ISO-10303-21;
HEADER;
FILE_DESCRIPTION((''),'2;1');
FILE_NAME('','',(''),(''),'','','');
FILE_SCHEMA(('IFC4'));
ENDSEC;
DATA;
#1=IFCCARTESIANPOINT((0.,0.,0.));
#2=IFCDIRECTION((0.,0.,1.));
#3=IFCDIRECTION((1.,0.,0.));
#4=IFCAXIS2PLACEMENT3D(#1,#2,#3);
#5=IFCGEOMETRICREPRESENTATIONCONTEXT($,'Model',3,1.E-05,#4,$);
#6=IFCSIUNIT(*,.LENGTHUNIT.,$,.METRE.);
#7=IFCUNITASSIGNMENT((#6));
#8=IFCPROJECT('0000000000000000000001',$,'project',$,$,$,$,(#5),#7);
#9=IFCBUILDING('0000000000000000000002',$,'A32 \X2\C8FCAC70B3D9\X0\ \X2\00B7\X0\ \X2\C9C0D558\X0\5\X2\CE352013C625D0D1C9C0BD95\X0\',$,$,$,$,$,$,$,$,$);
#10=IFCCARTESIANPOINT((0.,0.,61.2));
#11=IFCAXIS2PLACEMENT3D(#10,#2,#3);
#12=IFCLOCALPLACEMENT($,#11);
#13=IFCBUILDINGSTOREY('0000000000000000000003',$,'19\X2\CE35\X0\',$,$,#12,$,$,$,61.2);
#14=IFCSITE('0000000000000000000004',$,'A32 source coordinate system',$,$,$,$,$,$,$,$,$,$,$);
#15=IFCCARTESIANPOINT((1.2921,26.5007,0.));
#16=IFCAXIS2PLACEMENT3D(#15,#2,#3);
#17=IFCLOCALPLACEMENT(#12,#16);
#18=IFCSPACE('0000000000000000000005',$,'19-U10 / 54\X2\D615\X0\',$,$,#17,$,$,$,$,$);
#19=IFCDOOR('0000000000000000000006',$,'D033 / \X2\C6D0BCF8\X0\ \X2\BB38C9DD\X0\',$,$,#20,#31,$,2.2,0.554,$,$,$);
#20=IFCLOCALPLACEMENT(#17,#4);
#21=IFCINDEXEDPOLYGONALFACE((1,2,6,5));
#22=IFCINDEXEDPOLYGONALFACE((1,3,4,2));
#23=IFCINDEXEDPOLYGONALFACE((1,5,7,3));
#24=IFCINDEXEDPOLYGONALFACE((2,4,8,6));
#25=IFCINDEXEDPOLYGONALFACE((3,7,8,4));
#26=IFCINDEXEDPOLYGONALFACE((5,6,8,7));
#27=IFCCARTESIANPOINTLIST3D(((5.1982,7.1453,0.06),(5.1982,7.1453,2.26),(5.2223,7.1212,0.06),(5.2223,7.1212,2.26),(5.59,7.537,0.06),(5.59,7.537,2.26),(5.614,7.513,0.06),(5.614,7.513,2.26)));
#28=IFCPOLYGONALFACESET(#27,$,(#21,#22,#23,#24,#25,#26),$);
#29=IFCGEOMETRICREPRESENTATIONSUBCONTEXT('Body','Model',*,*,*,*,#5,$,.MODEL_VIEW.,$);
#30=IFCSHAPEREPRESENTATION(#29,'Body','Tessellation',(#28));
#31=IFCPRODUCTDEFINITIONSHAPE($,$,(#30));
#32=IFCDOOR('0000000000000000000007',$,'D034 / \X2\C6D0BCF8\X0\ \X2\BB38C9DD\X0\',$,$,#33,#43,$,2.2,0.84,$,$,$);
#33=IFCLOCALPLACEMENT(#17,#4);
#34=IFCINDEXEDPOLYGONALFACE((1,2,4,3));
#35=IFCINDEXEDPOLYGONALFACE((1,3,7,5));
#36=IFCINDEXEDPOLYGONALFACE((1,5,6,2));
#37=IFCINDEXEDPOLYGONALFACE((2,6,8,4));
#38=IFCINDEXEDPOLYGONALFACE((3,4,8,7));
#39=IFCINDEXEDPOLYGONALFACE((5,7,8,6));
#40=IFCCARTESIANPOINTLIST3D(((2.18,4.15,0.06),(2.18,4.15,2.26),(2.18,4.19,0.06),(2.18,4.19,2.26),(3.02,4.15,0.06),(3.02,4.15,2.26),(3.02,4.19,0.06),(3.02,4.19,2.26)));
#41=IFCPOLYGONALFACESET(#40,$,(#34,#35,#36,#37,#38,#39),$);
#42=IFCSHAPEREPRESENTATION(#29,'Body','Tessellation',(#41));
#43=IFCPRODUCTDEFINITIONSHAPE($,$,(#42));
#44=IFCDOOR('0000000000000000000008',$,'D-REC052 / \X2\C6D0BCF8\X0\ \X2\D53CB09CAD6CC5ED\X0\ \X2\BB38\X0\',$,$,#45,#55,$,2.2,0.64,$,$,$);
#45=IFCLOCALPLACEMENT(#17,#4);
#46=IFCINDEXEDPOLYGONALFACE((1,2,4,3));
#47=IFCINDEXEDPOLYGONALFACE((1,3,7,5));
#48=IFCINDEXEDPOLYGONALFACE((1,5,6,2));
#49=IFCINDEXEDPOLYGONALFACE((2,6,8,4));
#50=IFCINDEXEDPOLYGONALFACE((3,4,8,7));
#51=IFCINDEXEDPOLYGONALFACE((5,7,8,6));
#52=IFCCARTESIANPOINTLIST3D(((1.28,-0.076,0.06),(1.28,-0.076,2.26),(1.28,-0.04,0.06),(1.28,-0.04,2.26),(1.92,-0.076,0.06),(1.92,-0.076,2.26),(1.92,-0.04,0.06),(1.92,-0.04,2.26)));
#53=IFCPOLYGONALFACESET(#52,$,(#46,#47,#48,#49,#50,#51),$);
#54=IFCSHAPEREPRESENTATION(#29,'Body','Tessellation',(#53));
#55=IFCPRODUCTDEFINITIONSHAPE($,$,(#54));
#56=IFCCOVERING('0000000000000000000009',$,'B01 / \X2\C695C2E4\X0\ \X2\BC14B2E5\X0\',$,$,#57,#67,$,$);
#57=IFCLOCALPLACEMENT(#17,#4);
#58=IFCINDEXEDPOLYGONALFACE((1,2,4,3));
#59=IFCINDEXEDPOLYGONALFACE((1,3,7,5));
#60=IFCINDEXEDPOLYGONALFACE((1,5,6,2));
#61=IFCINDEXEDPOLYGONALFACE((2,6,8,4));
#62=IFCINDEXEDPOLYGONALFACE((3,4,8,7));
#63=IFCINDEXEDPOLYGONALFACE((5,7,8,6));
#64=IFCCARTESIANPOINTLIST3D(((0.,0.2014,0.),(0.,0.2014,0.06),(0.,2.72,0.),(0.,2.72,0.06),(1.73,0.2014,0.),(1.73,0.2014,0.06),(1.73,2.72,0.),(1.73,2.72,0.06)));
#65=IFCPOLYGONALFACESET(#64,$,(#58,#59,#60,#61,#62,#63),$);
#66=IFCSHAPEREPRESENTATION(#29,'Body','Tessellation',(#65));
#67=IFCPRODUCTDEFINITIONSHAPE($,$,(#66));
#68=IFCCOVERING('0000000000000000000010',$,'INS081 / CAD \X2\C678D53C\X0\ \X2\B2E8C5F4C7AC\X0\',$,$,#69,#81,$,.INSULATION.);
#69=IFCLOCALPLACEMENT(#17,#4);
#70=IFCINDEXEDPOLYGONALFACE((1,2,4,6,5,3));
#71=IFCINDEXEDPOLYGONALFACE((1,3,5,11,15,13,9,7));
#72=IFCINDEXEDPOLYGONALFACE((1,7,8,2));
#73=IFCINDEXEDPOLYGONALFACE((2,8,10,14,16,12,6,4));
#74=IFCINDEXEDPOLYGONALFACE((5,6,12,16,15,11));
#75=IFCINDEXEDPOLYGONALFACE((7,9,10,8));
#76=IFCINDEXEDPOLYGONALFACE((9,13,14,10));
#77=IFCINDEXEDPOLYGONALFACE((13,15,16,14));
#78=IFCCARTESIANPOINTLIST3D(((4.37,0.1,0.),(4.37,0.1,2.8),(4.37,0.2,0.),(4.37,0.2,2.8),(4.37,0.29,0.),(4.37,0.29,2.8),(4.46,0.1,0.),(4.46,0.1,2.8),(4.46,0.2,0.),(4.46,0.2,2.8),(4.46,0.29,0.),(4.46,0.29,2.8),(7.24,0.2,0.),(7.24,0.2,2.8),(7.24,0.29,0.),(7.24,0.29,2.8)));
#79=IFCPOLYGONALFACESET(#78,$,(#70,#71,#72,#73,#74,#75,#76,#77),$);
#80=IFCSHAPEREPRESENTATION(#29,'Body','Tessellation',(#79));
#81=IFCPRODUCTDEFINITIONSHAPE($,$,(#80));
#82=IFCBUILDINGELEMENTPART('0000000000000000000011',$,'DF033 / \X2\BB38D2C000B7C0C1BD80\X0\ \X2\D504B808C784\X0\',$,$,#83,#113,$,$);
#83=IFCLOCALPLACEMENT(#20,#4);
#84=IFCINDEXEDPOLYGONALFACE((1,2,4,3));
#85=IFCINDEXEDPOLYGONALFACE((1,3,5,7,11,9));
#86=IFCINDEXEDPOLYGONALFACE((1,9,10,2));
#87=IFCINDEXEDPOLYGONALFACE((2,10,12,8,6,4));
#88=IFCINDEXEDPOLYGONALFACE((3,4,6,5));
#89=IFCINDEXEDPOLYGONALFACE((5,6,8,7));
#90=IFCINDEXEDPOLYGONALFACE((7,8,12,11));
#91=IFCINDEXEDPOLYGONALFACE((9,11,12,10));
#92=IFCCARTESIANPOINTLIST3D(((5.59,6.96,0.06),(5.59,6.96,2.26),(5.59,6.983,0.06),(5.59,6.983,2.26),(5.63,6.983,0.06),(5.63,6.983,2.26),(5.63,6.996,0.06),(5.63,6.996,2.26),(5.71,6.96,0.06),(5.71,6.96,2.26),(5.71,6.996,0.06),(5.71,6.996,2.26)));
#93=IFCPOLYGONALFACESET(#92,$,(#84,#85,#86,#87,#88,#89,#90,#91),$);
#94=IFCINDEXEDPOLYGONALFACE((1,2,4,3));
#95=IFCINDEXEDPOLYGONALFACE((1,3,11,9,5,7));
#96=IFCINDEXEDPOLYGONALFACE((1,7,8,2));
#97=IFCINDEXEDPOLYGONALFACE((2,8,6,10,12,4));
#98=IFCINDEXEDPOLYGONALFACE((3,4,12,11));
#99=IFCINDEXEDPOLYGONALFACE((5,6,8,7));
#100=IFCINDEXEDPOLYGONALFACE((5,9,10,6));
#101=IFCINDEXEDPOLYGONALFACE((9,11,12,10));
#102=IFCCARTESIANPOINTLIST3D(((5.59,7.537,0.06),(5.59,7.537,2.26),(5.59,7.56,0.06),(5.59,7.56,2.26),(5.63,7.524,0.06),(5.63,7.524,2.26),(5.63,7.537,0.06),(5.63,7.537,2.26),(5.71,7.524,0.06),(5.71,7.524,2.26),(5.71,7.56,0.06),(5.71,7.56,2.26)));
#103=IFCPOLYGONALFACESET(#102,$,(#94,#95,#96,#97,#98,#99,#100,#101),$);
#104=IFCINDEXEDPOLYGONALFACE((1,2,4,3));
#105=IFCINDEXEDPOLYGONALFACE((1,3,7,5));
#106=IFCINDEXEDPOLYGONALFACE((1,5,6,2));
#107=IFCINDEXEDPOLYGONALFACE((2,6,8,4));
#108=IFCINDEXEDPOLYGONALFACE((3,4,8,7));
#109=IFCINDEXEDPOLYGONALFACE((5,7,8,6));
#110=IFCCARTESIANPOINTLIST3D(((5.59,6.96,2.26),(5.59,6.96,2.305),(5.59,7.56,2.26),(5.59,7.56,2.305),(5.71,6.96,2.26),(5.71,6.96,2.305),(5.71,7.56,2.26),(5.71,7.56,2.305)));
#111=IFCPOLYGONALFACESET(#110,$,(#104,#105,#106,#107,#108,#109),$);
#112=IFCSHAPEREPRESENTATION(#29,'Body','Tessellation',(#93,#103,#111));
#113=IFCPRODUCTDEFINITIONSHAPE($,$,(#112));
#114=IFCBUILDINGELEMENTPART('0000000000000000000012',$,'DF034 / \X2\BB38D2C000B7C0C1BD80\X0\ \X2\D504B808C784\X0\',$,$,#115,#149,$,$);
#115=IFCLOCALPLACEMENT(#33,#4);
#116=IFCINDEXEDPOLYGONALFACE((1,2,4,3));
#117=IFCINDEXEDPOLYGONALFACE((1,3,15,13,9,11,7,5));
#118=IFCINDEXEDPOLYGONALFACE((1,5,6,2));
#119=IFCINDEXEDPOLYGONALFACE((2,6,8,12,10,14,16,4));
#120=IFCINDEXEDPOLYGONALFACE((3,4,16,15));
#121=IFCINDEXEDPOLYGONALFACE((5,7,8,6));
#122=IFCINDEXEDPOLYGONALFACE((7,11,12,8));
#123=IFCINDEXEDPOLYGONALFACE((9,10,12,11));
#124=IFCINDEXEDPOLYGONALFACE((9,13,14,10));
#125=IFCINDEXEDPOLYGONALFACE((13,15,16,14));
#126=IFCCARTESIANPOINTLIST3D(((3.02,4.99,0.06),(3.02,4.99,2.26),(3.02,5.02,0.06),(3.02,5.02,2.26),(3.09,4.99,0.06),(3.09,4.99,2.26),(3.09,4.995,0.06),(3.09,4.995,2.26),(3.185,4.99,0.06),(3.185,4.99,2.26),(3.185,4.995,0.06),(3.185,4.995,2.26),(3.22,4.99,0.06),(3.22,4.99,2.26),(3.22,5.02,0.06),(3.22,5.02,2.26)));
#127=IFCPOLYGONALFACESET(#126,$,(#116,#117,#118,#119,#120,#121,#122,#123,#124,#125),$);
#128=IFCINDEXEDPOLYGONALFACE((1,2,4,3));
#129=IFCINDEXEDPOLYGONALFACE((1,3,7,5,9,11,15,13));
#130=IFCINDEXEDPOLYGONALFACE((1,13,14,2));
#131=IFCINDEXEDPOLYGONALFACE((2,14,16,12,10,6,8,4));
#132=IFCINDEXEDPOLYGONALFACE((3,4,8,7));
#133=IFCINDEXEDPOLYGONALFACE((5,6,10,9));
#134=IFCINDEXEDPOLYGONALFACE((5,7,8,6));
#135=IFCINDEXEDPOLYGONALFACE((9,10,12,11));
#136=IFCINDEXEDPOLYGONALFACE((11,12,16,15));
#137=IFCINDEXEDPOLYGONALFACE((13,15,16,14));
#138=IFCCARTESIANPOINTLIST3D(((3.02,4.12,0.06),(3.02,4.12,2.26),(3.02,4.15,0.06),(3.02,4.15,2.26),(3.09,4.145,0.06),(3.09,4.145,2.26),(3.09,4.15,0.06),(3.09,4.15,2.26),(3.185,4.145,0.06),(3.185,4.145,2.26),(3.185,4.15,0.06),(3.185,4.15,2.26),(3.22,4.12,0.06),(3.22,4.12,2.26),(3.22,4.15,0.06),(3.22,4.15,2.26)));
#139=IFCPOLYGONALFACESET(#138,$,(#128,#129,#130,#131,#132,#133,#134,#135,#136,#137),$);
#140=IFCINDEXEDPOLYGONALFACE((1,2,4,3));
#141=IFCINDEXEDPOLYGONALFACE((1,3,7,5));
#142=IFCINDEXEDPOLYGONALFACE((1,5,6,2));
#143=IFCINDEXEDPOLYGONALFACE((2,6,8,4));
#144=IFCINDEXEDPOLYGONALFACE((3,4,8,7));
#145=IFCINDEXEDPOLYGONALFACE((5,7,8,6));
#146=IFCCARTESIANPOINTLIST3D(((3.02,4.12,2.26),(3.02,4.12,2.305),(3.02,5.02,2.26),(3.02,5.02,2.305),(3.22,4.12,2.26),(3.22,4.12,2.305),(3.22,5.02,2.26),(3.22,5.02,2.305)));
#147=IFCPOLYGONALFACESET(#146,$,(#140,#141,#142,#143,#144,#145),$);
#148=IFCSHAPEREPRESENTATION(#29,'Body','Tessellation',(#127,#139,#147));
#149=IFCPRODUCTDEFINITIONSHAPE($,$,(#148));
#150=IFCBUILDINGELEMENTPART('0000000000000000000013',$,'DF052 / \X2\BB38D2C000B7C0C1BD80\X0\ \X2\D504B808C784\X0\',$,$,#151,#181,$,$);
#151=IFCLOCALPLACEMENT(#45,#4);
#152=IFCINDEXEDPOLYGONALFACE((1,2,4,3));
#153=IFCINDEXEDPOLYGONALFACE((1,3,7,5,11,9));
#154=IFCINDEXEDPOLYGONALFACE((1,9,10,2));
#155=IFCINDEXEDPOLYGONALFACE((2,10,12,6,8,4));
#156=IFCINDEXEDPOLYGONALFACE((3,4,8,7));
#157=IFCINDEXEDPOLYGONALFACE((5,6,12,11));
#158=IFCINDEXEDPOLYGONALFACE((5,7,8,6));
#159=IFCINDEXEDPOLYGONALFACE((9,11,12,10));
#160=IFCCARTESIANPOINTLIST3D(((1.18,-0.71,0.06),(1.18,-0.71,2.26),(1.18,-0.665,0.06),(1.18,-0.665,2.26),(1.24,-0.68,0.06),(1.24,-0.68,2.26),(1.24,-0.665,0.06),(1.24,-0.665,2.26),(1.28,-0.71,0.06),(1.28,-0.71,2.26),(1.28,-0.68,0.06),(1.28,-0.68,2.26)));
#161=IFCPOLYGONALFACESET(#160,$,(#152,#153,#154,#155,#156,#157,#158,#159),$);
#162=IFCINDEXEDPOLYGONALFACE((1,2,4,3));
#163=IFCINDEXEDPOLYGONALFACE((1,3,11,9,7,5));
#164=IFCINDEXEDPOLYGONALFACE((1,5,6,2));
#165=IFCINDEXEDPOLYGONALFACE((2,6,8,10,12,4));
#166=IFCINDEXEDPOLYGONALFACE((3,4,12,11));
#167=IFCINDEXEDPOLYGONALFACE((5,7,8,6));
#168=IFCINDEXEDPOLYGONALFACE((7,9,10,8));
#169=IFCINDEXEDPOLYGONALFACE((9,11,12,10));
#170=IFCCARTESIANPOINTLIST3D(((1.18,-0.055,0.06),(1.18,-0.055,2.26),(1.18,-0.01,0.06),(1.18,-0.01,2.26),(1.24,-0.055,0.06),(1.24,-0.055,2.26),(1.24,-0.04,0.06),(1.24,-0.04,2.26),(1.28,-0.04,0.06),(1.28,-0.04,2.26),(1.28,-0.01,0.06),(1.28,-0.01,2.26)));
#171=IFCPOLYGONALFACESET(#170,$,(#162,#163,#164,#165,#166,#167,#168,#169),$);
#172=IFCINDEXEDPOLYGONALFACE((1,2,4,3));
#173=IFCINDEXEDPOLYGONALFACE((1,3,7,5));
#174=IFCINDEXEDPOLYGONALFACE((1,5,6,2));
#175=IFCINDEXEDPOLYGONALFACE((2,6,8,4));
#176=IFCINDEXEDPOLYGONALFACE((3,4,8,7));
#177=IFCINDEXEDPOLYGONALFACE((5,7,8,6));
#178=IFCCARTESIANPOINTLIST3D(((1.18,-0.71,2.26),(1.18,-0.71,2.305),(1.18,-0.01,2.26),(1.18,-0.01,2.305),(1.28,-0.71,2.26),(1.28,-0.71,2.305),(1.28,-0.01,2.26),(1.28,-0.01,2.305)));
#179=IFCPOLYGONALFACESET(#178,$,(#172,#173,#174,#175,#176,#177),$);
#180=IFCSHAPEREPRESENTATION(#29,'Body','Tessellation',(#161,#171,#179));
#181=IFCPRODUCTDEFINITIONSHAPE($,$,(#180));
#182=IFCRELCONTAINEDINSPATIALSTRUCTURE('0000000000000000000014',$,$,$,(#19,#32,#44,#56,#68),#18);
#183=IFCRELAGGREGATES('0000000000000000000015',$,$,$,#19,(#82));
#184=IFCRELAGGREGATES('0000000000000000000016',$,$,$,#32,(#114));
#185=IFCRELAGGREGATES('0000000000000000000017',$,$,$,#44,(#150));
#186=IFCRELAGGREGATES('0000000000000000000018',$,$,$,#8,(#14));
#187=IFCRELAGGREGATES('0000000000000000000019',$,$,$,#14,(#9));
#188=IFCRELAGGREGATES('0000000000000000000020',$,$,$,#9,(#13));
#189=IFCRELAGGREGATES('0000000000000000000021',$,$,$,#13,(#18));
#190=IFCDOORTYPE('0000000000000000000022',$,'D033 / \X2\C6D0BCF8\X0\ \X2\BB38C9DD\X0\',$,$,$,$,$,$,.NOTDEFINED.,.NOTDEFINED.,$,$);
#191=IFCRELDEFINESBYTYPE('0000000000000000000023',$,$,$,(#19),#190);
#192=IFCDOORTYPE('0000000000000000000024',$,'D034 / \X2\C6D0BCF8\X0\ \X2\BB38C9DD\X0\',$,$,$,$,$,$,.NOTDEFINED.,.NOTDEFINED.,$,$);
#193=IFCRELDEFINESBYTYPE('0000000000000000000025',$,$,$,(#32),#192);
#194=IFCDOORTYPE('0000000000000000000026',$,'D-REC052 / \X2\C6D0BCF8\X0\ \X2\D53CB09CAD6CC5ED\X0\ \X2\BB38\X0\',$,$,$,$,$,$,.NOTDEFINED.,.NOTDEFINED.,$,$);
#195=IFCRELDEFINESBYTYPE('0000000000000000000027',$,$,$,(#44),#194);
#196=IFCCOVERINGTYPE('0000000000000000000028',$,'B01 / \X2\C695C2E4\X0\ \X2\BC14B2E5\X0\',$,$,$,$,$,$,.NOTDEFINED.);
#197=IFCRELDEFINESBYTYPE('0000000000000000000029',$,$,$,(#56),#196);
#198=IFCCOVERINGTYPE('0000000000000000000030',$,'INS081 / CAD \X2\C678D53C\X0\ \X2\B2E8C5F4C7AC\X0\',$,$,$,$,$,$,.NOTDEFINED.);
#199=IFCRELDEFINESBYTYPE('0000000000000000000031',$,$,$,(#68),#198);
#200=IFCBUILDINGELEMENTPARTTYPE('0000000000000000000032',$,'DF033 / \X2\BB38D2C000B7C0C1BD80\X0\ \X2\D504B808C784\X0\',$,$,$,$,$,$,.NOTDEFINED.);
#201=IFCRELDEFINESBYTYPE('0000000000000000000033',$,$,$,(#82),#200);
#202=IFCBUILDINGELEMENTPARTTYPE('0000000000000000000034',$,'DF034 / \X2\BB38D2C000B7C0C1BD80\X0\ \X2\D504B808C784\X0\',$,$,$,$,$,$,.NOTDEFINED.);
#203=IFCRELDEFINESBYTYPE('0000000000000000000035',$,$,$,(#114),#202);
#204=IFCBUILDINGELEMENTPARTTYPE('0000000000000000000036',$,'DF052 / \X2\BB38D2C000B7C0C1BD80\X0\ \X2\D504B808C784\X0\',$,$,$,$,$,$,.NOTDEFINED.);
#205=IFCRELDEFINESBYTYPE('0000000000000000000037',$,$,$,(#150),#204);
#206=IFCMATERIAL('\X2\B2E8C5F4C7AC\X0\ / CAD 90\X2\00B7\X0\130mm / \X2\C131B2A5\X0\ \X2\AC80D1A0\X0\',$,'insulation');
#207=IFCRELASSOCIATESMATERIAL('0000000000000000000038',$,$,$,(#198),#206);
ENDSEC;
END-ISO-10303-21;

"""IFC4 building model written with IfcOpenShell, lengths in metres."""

from ifc_helpers import new_model, si_unit, frame, origin, origin_with_axes, place, context, subcontext, project, spatial, polyline, outline, extrude, source, transform, mapped, material, type_object, type_shapes, element, aggregate, save


model = new_model("IFC4")

# Units and contexts
model_context = context("Model", 3, precision=1e-05, world=origin_with_axes())
body_context = subcontext(model_context, "Body", "Model", "MODEL_VIEW")
ifc_project = project(units=[si_unit("LENGTHUNIT", "METRE")], contexts=[model_context])

# Site, building, storey, space
storey_placement = place(None, frame((0.0, 0.0, 61.2), z_axis=(0.0, 0.0, 1.0), x_axis=(1.0, 0.0, 0.0)))
space_placement = place(storey_placement, frame((1.2921, 26.5007, 0.0), z_axis=(0.0, 0.0, 1.0), x_axis=(1.0, 0.0, 0.0)))
site = spatial("IfcSite", under=ifc_project, Name="A32 source coordinate system")
building = spatial("IfcBuilding", under=site, Name="A32 주거동 · 지하5층–옥탑지붕")
storey = spatial("IfcBuildingStorey", under=building, at=storey_placement, Name="19층", Elevation=61.2)
space = spatial("IfcSpace", under=storey, at=space_placement, Name="19-U10 / 54형")

# Doors
door_type_1 = type_object("IfcDoorType", Name="D033 / 원본 문짝", OperationType="NOTDEFINED", PredefinedType="NOTDEFINED")
shared_shape_1 = source(origin(), body_context, "Body", "SweptSolid", [
    extrude(outline(polyline([(5.2223, 7.1212), (5.1982, 7.1453), (5.59, 7.537), (5.614, 7.513), (5.2223, 7.1212)])), frame((0.0, 0.0, 0.06)), (0.0, 0.0, 1.0), 2.2),
])
type_shapes(door_type_1, [shared_shape_1])
door_1_placement = place(space_placement, origin_with_axes())
door_1 = element("IfcDoor", 1, at=door_1_placement, inside=space, type_object=door_type_1, Name="D033 / 원본 문짝", OverallHeight=2.2, OverallWidth=0.554, context=body_context, shape_type="MappedRepresentation", body=[
    mapped(shared_shape_1, transform((0.0, 0.0, 0.0), scale=1.0)),
])
door_type_2 = type_object("IfcDoorType", Name="D034 / 원본 문짝", OperationType="NOTDEFINED", PredefinedType="NOTDEFINED")
shared_shape_2 = source(origin(), body_context, "Body", "SweptSolid", [
    extrude(outline(polyline([(3.02, 4.15), (2.18, 4.15), (2.18, 4.19), (3.02, 4.19), (3.02, 4.15)])), frame((0.0, 0.0, 0.06)), (0.0, 0.0, 1.0), 2.2),
])
type_shapes(door_type_2, [shared_shape_2])
door_2_placement = place(space_placement, origin_with_axes())
door_2 = element("IfcDoor", 2, at=door_2_placement, inside=space, type_object=door_type_2, Name="D034 / 원본 문짝", OverallHeight=2.2, OverallWidth=0.84, context=body_context, shape_type="MappedRepresentation", body=[
    mapped(shared_shape_2, transform((0.0, 0.0, 0.0), scale=1.0)),
])
door_type_3 = type_object("IfcDoorType", Name="D-REC052 / 원본 피난구역 문", OperationType="NOTDEFINED", PredefinedType="NOTDEFINED")
shared_shape_3 = source(origin(), body_context, "Body", "SweptSolid", [
    extrude(outline(polyline([(1.92, -0.076), (1.28, -0.076), (1.28, -0.04), (1.92, -0.04), (1.92, -0.076)])), frame((0.0, 0.0, 0.06)), (0.0, 0.0, 1.0), 2.2),
])
type_shapes(door_type_3, [shared_shape_3])
door_3_placement = place(space_placement, origin_with_axes())
door_3 = element("IfcDoor", 3, at=door_3_placement, inside=space, type_object=door_type_3, Name="D-REC052 / 원본 피난구역 문", OverallHeight=2.2, OverallWidth=0.64, context=body_context, shape_type="MappedRepresentation", body=[
    mapped(shared_shape_3, transform((0.0, 0.0, 0.0), scale=1.0)),
])

# Coverings
covering_type_1 = type_object("IfcCoveringType", Name="B01 / 욕실 바닥", PredefinedType="NOTDEFINED")
shared_shape_4 = source(origin(), body_context, "Body", "SweptSolid", [
    extrude(outline(polyline([(0.0, 0.2014), (0.0, 2.72), (1.73, 2.72), (1.73, 0.2014), (0.0, 0.2014)])), origin(), (0.0, 0.0, 1.0), 0.06),
])
type_shapes(covering_type_1, [shared_shape_4])
covering_1_placement = place(space_placement, origin_with_axes())
element("IfcCovering", 4, at=covering_1_placement, inside=space, type_object=covering_type_1, Name="B01 / 욕실 바닥", context=body_context, shape_type="MappedRepresentation", body=[
    mapped(shared_shape_4, transform((0.0, 0.0, 0.0), scale=1.0)),
])
ifc_material = material(Name="단열재 / CAD 90·130mm / 성능 검토", Category="insulation")
covering_type_2 = type_object("IfcCoveringType", Name="INS081 / CAD 외피 단열재", PredefinedType="NOTDEFINED", material=ifc_material)
shared_shape_5 = source(origin(), body_context, "Body", "SweptSolid", [
    extrude(outline(polyline([(4.37, 0.2), (4.37, 0.29), (4.46, 0.29), (7.24, 0.29), (7.24, 0.2), (4.46, 0.2), (4.46, 0.1), (4.37, 0.1), (4.37, 0.2)])), origin(), (0.0, 0.0, 1.0), 2.8),
])
type_shapes(covering_type_2, [shared_shape_5])
covering_2_placement = place(space_placement, origin_with_axes())
element("IfcCovering", 5, at=covering_2_placement, inside=space, type_object=covering_type_2, Name="INS081 / CAD 외피 단열재", PredefinedType="INSULATION", context=body_context, shape_type="MappedRepresentation", body=[
    mapped(shared_shape_5, transform((0.0, 0.0, 0.0), scale=1.0)),
])

# Building element parts
building_element_part_type_1 = type_object("IfcBuildingElementPartType", Name="DF033 / 문틀·상부 프레임", PredefinedType="NOTDEFINED")
shared_shape_6 = source(origin(), body_context, "Body", "SweptSolid", [
    extrude(outline(polyline([(5.59, 6.96), (5.59, 6.983), (5.63, 6.983), (5.63, 6.996), (5.71, 6.996), (5.71, 6.96), (5.59, 6.96)])), frame((0.0, 0.0, 0.06)), (0.0, 0.0, 1.0), 2.2),
    extrude(outline(polyline([(5.71, 7.524), (5.63, 7.524), (5.63, 7.537), (5.59, 7.537), (5.59, 7.56), (5.71, 7.56), (5.71, 7.524)])), frame((0.0, 0.0, 0.06)), (0.0, 0.0, 1.0), 2.2),
    extrude(outline(polyline([(5.59, 6.96), (5.59, 7.56), (5.71, 7.56), (5.71, 6.96), (5.59, 6.96)])), frame((0.0, 0.0, 2.26)), (0.0, 0.0, 1.0), 0.045),
])
type_shapes(building_element_part_type_1, [shared_shape_6])
building_element_part_1_placement = place(door_1_placement, origin_with_axes())
building_element_part_1 = element("IfcBuildingElementPart", 6, at=building_element_part_1_placement, type_object=building_element_part_type_1, Name="DF033 / 문틀·상부 프레임", context=body_context, shape_type="MappedRepresentation", body=[
    mapped(shared_shape_6, transform((0.0, 0.0, 0.0), scale=1.0)),
])
aggregate(door_1, [building_element_part_1])
building_element_part_type_2 = type_object("IfcBuildingElementPartType", Name="DF034 / 문틀·상부 프레임", PredefinedType="NOTDEFINED")
shared_shape_7 = source(origin(), body_context, "Body", "SweptSolid", [
    extrude(outline(polyline([(3.22, 5.02), (3.22, 4.99), (3.185, 4.99), (3.185, 4.995), (3.09, 4.995), (3.09, 4.99), (3.02, 4.99), (3.02, 5.02), (3.22, 5.02)])), frame((0.0, 0.0, 0.06)), (0.0, 0.0, 1.0), 2.2),
    extrude(outline(polyline([(3.02, 4.15), (3.09, 4.15), (3.09, 4.145), (3.185, 4.145), (3.185, 4.15), (3.22, 4.15), (3.22, 4.12), (3.02, 4.12), (3.02, 4.15)])), frame((0.0, 0.0, 0.06)), (0.0, 0.0, 1.0), 2.2),
    extrude(outline(polyline([(3.02, 4.12), (3.02, 5.02), (3.22, 5.02), (3.22, 4.12), (3.02, 4.12)])), frame((0.0, 0.0, 2.26)), (0.0, 0.0, 1.0), 0.045),
])
type_shapes(building_element_part_type_2, [shared_shape_7])
building_element_part_2_placement = place(door_2_placement, origin_with_axes())
building_element_part_2 = element("IfcBuildingElementPart", 7, at=building_element_part_2_placement, type_object=building_element_part_type_2, Name="DF034 / 문틀·상부 프레임", context=body_context, shape_type="MappedRepresentation", body=[
    mapped(shared_shape_7, transform((0.0, 0.0, 0.0), scale=1.0)),
])
aggregate(door_2, [building_element_part_2])
building_element_part_type_3 = type_object("IfcBuildingElementPartType", Name="DF052 / 문틀·상부 프레임", PredefinedType="NOTDEFINED")
shared_shape_8 = source(origin(), body_context, "Body", "SweptSolid", [
    extrude(outline(polyline([(1.18, -0.71), (1.18, -0.665), (1.24, -0.665), (1.24, -0.68), (1.28, -0.68), (1.28, -0.71), (1.18, -0.71)])), frame((0.0, 0.0, 0.06)), (0.0, 0.0, 1.0), 2.2),
    extrude(outline(polyline([(1.28, -0.04), (1.24, -0.04), (1.24, -0.055), (1.18, -0.055), (1.18, -0.01), (1.28, -0.01), (1.28, -0.04)])), frame((0.0, 0.0, 0.06)), (0.0, 0.0, 1.0), 2.2),
    extrude(outline(polyline([(1.18, -0.71), (1.18, -0.01), (1.28, -0.01), (1.28, -0.71), (1.18, -0.71)])), frame((0.0, 0.0, 2.26)), (0.0, 0.0, 1.0), 0.045),
])
type_shapes(building_element_part_type_3, [shared_shape_8])
building_element_part_3_placement = place(door_3_placement, origin_with_axes())
building_element_part_3 = element("IfcBuildingElementPart", 8, at=building_element_part_3_placement, type_object=building_element_part_type_3, Name="DF052 / 문틀·상부 프레임", context=body_context, shape_type="MappedRepresentation", body=[
    mapped(shared_shape_8, transform((0.0, 0.0, 0.0), scale=1.0)),
])
aggregate(door_3, [building_element_part_3])

save(model, "model.ifc")
